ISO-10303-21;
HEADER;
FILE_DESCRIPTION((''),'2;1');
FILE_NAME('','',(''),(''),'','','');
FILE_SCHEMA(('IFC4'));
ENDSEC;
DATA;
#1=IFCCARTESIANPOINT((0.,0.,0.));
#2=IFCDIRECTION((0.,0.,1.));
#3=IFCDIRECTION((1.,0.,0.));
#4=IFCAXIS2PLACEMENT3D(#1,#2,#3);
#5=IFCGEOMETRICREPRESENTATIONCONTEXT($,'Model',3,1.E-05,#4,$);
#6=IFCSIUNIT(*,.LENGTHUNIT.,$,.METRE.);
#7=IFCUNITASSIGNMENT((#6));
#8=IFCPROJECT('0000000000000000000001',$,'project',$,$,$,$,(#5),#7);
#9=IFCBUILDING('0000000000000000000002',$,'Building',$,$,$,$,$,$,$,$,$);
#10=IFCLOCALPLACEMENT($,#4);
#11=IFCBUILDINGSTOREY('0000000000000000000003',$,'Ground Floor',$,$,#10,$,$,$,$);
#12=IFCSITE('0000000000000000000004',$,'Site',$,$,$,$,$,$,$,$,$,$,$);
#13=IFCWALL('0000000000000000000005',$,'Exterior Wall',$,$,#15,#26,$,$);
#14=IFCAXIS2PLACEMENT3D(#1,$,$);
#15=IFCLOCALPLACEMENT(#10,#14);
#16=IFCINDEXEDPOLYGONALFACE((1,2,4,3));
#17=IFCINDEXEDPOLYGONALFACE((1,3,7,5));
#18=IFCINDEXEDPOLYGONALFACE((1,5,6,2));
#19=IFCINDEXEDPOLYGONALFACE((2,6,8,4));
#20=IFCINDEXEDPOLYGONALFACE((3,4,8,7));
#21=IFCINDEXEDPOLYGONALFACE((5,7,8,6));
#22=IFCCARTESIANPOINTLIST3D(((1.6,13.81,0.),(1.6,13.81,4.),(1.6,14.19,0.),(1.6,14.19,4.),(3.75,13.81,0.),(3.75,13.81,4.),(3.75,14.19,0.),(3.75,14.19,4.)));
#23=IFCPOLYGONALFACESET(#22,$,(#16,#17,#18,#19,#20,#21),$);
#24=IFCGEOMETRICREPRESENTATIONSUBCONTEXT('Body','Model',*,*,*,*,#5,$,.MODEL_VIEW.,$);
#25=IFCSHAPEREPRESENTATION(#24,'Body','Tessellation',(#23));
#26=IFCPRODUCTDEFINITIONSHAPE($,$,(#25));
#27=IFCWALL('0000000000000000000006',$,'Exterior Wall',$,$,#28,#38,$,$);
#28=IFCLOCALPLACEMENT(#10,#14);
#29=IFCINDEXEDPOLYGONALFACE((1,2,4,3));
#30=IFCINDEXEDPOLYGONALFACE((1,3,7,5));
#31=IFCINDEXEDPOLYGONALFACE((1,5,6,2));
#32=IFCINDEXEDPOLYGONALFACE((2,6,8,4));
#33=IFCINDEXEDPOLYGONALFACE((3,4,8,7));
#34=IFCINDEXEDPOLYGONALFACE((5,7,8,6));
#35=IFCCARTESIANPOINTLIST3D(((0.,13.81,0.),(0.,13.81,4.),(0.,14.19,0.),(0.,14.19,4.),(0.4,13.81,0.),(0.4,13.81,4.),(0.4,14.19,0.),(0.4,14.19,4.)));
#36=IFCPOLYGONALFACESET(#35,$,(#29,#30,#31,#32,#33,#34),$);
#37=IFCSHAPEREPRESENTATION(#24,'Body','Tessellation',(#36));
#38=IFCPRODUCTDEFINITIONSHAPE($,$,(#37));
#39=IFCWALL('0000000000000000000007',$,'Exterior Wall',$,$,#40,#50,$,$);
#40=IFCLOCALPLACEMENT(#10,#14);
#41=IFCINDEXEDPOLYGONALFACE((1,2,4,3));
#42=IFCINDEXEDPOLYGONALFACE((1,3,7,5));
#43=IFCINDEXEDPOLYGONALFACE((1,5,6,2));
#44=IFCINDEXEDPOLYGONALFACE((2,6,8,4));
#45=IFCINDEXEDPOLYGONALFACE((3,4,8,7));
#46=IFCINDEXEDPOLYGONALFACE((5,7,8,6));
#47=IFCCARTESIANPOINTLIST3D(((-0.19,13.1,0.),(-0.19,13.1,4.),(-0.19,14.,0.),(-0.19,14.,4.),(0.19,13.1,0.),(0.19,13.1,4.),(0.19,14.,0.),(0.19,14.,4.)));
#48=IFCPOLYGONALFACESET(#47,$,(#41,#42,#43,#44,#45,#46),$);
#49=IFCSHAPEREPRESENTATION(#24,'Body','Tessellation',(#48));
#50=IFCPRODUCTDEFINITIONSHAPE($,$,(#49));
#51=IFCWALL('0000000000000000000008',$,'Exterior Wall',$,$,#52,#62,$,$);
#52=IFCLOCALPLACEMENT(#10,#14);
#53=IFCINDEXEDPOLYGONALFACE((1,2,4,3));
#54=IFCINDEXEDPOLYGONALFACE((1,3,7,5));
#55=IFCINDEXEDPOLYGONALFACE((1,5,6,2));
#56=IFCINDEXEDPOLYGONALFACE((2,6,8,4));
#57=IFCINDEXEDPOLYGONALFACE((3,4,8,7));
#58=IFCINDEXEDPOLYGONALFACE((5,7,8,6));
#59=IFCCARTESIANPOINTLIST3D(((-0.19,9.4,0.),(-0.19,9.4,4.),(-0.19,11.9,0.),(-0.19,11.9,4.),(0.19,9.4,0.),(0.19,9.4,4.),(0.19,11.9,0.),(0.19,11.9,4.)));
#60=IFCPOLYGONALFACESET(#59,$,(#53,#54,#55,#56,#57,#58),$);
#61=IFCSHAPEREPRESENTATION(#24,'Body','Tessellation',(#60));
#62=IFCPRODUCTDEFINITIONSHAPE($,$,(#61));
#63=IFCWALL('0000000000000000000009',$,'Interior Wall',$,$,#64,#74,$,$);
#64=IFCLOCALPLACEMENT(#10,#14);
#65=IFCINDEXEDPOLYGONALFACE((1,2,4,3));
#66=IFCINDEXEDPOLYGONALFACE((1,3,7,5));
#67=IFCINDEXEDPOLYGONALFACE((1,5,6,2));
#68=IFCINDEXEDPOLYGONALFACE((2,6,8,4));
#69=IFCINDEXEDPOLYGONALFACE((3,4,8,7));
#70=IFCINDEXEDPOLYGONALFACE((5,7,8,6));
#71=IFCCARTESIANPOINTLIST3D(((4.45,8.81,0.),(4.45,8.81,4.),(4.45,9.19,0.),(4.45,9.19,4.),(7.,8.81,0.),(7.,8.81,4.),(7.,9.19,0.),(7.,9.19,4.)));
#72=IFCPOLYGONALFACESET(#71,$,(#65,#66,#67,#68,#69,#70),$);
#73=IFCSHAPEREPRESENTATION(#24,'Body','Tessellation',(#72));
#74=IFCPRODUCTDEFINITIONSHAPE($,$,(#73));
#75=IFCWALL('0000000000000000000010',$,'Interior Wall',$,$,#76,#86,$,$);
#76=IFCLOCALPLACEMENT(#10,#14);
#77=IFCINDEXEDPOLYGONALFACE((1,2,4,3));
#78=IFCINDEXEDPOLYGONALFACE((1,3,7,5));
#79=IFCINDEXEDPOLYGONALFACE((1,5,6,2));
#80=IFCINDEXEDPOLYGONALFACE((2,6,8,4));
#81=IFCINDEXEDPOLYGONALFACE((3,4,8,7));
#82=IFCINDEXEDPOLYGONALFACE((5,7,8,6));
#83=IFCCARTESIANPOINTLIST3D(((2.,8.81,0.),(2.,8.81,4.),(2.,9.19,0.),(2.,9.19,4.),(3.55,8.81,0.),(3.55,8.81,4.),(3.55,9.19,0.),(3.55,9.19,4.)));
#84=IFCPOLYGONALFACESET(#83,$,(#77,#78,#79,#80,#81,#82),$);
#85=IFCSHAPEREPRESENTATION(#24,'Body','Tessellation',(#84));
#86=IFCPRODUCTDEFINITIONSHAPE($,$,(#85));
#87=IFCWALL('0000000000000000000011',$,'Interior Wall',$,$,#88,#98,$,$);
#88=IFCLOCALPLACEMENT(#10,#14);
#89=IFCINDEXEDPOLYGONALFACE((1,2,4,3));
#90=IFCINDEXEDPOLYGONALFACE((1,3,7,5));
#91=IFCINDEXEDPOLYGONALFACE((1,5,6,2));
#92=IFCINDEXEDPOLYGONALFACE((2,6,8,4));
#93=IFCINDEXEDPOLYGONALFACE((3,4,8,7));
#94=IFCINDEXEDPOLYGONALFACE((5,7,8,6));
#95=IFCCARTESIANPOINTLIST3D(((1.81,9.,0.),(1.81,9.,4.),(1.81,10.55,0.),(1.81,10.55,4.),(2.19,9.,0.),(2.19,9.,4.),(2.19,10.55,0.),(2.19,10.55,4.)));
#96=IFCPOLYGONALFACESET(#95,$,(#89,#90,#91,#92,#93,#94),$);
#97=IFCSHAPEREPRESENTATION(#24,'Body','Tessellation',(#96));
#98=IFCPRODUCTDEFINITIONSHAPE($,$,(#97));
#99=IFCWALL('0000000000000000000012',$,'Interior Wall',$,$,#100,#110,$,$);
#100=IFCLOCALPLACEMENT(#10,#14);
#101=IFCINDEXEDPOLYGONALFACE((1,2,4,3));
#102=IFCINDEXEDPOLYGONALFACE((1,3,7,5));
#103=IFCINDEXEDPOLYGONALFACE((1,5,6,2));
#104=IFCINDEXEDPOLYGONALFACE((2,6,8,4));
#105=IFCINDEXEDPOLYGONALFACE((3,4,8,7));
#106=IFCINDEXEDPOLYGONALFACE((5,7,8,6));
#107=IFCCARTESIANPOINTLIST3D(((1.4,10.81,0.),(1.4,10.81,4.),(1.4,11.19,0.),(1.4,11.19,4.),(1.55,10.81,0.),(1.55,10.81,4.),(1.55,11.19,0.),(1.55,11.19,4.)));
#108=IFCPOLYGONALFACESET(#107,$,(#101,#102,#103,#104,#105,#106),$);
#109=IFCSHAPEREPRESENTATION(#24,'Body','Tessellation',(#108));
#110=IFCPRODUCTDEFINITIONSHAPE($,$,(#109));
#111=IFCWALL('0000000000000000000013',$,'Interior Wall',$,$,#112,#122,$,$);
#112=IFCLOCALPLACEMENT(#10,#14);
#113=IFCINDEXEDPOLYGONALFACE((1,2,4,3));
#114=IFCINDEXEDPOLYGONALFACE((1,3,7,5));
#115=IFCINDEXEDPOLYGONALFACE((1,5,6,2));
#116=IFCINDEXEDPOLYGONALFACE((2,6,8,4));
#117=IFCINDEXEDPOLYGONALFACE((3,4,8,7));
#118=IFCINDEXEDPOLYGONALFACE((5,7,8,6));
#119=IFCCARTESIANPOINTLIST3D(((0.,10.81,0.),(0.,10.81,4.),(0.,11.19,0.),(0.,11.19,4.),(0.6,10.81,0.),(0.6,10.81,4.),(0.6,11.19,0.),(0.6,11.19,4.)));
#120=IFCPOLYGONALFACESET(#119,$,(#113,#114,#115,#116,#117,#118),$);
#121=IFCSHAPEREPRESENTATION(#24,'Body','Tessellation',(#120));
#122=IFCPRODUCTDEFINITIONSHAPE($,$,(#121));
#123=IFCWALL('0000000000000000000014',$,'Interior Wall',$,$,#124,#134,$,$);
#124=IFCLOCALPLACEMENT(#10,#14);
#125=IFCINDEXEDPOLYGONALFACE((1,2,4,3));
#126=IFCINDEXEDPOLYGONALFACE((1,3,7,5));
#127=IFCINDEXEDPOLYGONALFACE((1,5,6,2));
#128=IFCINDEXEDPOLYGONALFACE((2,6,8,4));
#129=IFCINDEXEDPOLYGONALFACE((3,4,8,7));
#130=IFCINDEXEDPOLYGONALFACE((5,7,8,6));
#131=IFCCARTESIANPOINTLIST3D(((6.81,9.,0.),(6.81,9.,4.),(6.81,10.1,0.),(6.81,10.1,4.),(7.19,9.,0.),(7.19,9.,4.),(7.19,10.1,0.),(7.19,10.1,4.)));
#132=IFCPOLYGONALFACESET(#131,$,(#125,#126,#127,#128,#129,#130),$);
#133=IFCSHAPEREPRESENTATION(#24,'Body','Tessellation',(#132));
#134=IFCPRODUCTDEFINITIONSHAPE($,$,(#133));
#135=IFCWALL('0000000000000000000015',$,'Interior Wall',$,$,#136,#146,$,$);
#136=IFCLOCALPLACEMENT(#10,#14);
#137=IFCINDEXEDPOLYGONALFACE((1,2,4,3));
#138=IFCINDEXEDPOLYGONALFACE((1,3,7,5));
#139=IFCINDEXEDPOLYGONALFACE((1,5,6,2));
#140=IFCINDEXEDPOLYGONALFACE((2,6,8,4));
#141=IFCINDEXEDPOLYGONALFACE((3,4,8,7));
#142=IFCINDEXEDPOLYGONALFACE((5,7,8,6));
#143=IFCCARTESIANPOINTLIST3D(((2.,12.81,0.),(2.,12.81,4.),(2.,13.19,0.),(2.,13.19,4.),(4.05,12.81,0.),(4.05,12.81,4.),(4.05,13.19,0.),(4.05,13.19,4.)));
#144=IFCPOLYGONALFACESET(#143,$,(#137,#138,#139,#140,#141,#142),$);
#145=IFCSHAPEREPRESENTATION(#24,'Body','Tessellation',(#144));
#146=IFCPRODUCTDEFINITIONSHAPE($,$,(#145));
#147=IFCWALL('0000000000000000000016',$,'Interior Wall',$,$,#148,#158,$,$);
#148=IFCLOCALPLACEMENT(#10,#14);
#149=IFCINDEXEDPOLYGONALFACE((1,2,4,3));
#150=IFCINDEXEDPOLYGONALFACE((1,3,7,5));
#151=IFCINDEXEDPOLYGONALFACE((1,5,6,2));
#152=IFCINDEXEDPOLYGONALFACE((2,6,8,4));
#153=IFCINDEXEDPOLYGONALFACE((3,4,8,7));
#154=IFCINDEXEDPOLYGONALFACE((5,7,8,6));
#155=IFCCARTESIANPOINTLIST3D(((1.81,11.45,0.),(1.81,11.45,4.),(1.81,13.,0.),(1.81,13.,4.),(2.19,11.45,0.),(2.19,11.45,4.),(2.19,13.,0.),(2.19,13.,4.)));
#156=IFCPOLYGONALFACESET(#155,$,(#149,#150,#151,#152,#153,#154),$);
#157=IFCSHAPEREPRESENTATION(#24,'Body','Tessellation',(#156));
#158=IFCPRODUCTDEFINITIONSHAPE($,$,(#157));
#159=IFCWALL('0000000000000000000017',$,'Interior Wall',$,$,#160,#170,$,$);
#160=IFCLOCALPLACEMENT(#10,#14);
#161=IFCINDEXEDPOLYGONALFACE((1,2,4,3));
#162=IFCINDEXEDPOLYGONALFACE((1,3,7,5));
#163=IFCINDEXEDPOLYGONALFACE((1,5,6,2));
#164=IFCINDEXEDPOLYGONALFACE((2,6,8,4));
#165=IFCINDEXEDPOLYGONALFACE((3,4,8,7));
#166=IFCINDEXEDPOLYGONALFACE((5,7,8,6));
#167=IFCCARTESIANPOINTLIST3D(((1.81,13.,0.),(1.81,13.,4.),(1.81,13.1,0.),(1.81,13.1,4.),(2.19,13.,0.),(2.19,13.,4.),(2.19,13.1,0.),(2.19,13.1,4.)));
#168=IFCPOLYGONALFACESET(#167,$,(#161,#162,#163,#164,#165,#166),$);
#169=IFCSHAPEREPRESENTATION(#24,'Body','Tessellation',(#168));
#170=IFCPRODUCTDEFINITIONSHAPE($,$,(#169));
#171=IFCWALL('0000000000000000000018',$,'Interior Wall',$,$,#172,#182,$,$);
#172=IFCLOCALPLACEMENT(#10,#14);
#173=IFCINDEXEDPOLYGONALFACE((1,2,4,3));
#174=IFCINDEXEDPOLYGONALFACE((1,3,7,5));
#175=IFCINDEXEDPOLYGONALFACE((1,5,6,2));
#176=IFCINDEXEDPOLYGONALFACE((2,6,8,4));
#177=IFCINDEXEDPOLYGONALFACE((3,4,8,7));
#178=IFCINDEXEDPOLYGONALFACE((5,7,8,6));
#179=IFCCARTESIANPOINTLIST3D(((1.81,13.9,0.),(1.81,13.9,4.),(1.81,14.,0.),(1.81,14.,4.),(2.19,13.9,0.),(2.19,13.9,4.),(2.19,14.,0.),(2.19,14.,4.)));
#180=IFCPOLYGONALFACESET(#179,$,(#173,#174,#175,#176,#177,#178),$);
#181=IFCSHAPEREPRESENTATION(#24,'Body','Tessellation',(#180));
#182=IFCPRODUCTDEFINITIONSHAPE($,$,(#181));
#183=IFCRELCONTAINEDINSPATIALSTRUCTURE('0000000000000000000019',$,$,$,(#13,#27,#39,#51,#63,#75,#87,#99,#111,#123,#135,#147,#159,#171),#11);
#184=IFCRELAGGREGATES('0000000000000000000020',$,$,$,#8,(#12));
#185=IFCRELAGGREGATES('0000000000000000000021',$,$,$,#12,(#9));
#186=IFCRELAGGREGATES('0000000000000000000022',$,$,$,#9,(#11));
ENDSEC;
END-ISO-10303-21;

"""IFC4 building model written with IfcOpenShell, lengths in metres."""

from ifc_helpers import new_model, si_unit, frame, origin_with_axes, place, context, subcontext, project, spatial, indexed_curve, outline, extrude, element, save


model = new_model("IFC4")

# Units and contexts
model_context = context("Model", 3, precision=1e-05, world=origin_with_axes())
body_context = subcontext(model_context, "Body", "Model", "MODEL_VIEW")
ifc_project = project(units=[si_unit("LENGTHUNIT", "METRE")], contexts=[model_context])

# Site, building, storey
site = spatial("IfcSite", under=ifc_project, Name="Site")
building = spatial("IfcBuilding", under=site, Name="Building")
storey_placement = place(None, origin_with_axes())
storey = spatial("IfcBuildingStorey", under=building, at=storey_placement, Name="Ground Floor")

# Walls
wall_1_placement = place(storey_placement, frame((3.75, 14.0, 0.0), z_axis=(0.0, 0.0, 1.0), x_axis=(-1.0, 0.0, 0.0)))
element("IfcWall", 1, at=wall_1_placement, inside=storey, Name="Exterior Wall", context=body_context, shape_type="SweptSolid", body=[
    extrude(outline(indexed_curve([(0.0, 0.0), (0.0, 0.38), (2.15, 0.38), (2.15, 0.0), (0.0, 0.0)], self_intersect=False)), frame((0.0, -0.19, 0.0), z_axis=(0.0, 0.0, 1.0), x_axis=(1.0, 0.0, 0.0)), (0.0, 0.0, 1.0), 4.0),
])
wall_2_placement = place(storey_placement, frame((0.4, 14.0, 0.0), z_axis=(0.0, 0.0, 1.0), x_axis=(-1.0, 0.0, 0.0)))
element("IfcWall", 2, at=wall_2_placement, inside=storey, Name="Exterior Wall", context=body_context, shape_type="SweptSolid", body=[
    extrude(outline(indexed_curve([(0.0, 0.0), (0.0, 0.38), (0.4, 0.38), (0.4, 0.0), (0.0, 0.0)], self_intersect=False)), frame((0.0, -0.19, 0.0), z_axis=(0.0, 0.0, 1.0), x_axis=(1.0, 0.0, 0.0)), (0.0, 0.0, 1.0), 4.0),
])
wall_3_placement = place(storey_placement, frame((0.0, 14.0, 0.0), z_axis=(0.0, 0.0, 1.0), x_axis=(0.0, -1.0, 0.0)))
element("IfcWall", 3, at=wall_3_placement, inside=storey, Name="Exterior Wall", context=body_context, shape_type="SweptSolid", body=[
    extrude(outline(indexed_curve([(0.0, 0.0), (0.0, 0.38), (0.9, 0.38), (0.9, 0.0), (0.0, 0.0)], self_intersect=False)), frame((0.0, -0.19, 0.0), z_axis=(0.0, 0.0, 1.0), x_axis=(1.0, 0.0, 0.0)), (0.0, 0.0, 1.0), 4.0),
])
wall_4_placement = place(storey_placement, frame((0.0, 11.9, 0.0), z_axis=(0.0, 0.0, 1.0), x_axis=(0.0, -1.0, 0.0)))
element("IfcWall", 4, at=wall_4_placement, inside=storey, Name="Exterior Wall", context=body_context, shape_type="SweptSolid", body=[
    extrude(outline(indexed_curve([(0.0, 0.0), (0.0, 0.38), (2.5, 0.38), (2.5, 0.0), (0.0, 0.0)], self_intersect=False)), frame((0.0, -0.19, 0.0), z_axis=(0.0, 0.0, 1.0), x_axis=(1.0, 0.0, 0.0)), (0.0, 0.0, 1.0), 4.0),
])
wall_5_placement = place(storey_placement, frame((7.0, 9.0, 0.0), z_axis=(0.0, 0.0, 1.0), x_axis=(-1.0, 0.0, 0.0)))
element("IfcWall", 5, at=wall_5_placement, inside=storey, Name="Interior Wall", context=body_context, shape_type="SweptSolid", body=[
    extrude(outline(indexed_curve([(0.0, 0.0), (0.0, 0.38), (2.55, 0.38), (2.55, 0.0), (0.0, 0.0)], self_intersect=False)), frame((0.0, -0.19, 0.0), z_axis=(0.0, 0.0, 1.0), x_axis=(1.0, 0.0, 0.0)), (0.0, 0.0, 1.0), 4.0),
])
wall_6_placement = place(storey_placement, frame((3.55, 9.0, 0.0), z_axis=(0.0, 0.0, 1.0), x_axis=(-1.0, 0.0, 0.0)))
element("IfcWall", 6, at=wall_6_placement, inside=storey, Name="Interior Wall", context=body_context, shape_type="SweptSolid", body=[
    extrude(outline(indexed_curve([(0.0, 0.0), (0.0, 0.38), (1.55, 0.38), (1.55, 0.0), (0.0, 0.0)], self_intersect=False)), frame((0.0, -0.19, 0.0), z_axis=(0.0, 0.0, 1.0), x_axis=(1.0, 0.0, 0.0)), (0.0, 0.0, 1.0), 4.0),
])
wall_7_placement = place(storey_placement, frame((2.0, 9.0, 0.0), z_axis=(0.0, 0.0, 1.0), x_axis=(0.0, 1.0, 0.0)))
element("IfcWall", 7, at=wall_7_placement, inside=storey, Name="Interior Wall", context=body_context, shape_type="SweptSolid", body=[
    extrude(outline(indexed_curve([(0.0, 0.0), (0.0, 0.38), (1.55, 0.38), (1.55, 0.0), (0.0, 0.0)], self_intersect=False)), frame((0.0, -0.19, 0.0), z_axis=(0.0, 0.0, 1.0), x_axis=(1.0, 0.0, 0.0)), (0.0, 0.0, 1.0), 4.0),
])
wall_8_placement = place(storey_placement, frame((1.55, 11.0, 0.0), z_axis=(0.0, 0.0, 1.0), x_axis=(-1.0, 0.0, 0.0)))
element("IfcWall", 8, at=wall_8_placement, inside=storey, Name="Interior Wall", context=body_context, shape_type="SweptSolid", body=[
    extrude(outline(indexed_curve([(0.0, 0.0), (0.0, 0.38), (0.15, 0.38), (0.15, 0.0), (0.0, 0.0)], self_intersect=False)), frame((0.0, -0.19, 0.0), z_axis=(0.0, 0.0, 1.0), x_axis=(1.0, 0.0, 0.0)), (0.0, 0.0, 1.0), 4.0),
])
wall_9_placement = place(storey_placement, frame((0.6, 11.0, 0.0), z_axis=(0.0, 0.0, 1.0), x_axis=(-1.0, 0.0, 0.0)))
element("IfcWall", 9, at=wall_9_placement, inside=storey, Name="Interior Wall", context=body_context, shape_type="SweptSolid", body=[
    extrude(outline(indexed_curve([(0.0, 0.0), (0.0, 0.38), (0.6, 0.38), (0.6, 0.0), (0.0, 0.0)], self_intersect=False)), frame((0.0, -0.19, 0.0), z_axis=(0.0, 0.0, 1.0), x_axis=(1.0, 0.0, 0.0)), (0.0, 0.0, 1.0), 4.0),
])
wall_10_placement = place(storey_placement, frame((7.0, 9.0, 0.0), z_axis=(0.0, 0.0, 1.0), x_axis=(0.0, 1.0, 0.0)))
element("IfcWall", 10, at=wall_10_placement, inside=storey, Name="Interior Wall", context=body_context, shape_type="SweptSolid", body=[
    extrude(outline(indexed_curve([(0.0, 0.0), (0.0, 0.38), (1.1, 0.38), (1.1, 0.0), (0.0, 0.0)], self_intersect=False)), frame((0.0, -0.19, 0.0), z_axis=(0.0, 0.0, 1.0), x_axis=(1.0, 0.0, 0.0)), (0.0, 0.0, 1.0), 4.0),
])
wall_11_placement = place(storey_placement, frame((4.05, 13.0, 0.0), z_axis=(0.0, 0.0, 1.0), x_axis=(-1.0, 0.0, 0.0)))
element("IfcWall", 11, at=wall_11_placement, inside=storey, Name="Interior Wall", context=body_context, shape_type="SweptSolid", body=[
    extrude(outline(indexed_curve([(0.0, 0.0), (0.0, 0.38), (2.05, 0.38), (2.05, 0.0), (0.0, 0.0)], self_intersect=False)), frame((0.0, -0.19, 0.0), z_axis=(0.0, 0.0, 1.0), x_axis=(1.0, 0.0, 0.0)), (0.0, 0.0, 1.0), 4.0),
])
wall_12_placement = place(storey_placement, frame((2.0, 13.0, 0.0), z_axis=(0.0, 0.0, 1.0), x_axis=(0.0, -1.0, 0.0)))
element("IfcWall", 12, at=wall_12_placement, inside=storey, Name="Interior Wall", context=body_context, shape_type="SweptSolid", body=[
    extrude(outline(indexed_curve([(0.0, 0.0), (0.0, 0.38), (1.55, 0.38), (1.55, 0.0), (0.0, 0.0)], self_intersect=False)), frame((0.0, -0.19, 0.0), z_axis=(0.0, 0.0, 1.0), x_axis=(1.0, 0.0, 0.0)), (0.0, 0.0, 1.0), 4.0),
])
for number, where, z_axis, x_axis, name in (
    (13, (2.0, 13.0, 0.0), (0.0, 0.0, 1.0), (0.0, 1.0, 0.0), "Interior Wall"),
    (14, (2.0, 13.9, 0.0), (0.0, 0.0, 1.0), (0.0, 1.0, 0.0), "Interior Wall"),
):
    element("IfcWall", number, at=place(storey_placement, frame(where, z_axis=z_axis, x_axis=x_axis)), inside=storey, Name=name, context=body_context, shape_type="SweptSolid", body=[
        extrude(outline(indexed_curve([(0.0, 0.0), (0.0, 0.38), (0.1, 0.38), (0.1, 0.0), (0.0, 0.0)], self_intersect=False)), frame((0.0, -0.19, 0.0), z_axis=(0.0, 0.0, 1.0), x_axis=(1.0, 0.0, 0.0)), (0.0, 0.0, 1.0), 4.0),
    ])

save(model, "model.ifc")
